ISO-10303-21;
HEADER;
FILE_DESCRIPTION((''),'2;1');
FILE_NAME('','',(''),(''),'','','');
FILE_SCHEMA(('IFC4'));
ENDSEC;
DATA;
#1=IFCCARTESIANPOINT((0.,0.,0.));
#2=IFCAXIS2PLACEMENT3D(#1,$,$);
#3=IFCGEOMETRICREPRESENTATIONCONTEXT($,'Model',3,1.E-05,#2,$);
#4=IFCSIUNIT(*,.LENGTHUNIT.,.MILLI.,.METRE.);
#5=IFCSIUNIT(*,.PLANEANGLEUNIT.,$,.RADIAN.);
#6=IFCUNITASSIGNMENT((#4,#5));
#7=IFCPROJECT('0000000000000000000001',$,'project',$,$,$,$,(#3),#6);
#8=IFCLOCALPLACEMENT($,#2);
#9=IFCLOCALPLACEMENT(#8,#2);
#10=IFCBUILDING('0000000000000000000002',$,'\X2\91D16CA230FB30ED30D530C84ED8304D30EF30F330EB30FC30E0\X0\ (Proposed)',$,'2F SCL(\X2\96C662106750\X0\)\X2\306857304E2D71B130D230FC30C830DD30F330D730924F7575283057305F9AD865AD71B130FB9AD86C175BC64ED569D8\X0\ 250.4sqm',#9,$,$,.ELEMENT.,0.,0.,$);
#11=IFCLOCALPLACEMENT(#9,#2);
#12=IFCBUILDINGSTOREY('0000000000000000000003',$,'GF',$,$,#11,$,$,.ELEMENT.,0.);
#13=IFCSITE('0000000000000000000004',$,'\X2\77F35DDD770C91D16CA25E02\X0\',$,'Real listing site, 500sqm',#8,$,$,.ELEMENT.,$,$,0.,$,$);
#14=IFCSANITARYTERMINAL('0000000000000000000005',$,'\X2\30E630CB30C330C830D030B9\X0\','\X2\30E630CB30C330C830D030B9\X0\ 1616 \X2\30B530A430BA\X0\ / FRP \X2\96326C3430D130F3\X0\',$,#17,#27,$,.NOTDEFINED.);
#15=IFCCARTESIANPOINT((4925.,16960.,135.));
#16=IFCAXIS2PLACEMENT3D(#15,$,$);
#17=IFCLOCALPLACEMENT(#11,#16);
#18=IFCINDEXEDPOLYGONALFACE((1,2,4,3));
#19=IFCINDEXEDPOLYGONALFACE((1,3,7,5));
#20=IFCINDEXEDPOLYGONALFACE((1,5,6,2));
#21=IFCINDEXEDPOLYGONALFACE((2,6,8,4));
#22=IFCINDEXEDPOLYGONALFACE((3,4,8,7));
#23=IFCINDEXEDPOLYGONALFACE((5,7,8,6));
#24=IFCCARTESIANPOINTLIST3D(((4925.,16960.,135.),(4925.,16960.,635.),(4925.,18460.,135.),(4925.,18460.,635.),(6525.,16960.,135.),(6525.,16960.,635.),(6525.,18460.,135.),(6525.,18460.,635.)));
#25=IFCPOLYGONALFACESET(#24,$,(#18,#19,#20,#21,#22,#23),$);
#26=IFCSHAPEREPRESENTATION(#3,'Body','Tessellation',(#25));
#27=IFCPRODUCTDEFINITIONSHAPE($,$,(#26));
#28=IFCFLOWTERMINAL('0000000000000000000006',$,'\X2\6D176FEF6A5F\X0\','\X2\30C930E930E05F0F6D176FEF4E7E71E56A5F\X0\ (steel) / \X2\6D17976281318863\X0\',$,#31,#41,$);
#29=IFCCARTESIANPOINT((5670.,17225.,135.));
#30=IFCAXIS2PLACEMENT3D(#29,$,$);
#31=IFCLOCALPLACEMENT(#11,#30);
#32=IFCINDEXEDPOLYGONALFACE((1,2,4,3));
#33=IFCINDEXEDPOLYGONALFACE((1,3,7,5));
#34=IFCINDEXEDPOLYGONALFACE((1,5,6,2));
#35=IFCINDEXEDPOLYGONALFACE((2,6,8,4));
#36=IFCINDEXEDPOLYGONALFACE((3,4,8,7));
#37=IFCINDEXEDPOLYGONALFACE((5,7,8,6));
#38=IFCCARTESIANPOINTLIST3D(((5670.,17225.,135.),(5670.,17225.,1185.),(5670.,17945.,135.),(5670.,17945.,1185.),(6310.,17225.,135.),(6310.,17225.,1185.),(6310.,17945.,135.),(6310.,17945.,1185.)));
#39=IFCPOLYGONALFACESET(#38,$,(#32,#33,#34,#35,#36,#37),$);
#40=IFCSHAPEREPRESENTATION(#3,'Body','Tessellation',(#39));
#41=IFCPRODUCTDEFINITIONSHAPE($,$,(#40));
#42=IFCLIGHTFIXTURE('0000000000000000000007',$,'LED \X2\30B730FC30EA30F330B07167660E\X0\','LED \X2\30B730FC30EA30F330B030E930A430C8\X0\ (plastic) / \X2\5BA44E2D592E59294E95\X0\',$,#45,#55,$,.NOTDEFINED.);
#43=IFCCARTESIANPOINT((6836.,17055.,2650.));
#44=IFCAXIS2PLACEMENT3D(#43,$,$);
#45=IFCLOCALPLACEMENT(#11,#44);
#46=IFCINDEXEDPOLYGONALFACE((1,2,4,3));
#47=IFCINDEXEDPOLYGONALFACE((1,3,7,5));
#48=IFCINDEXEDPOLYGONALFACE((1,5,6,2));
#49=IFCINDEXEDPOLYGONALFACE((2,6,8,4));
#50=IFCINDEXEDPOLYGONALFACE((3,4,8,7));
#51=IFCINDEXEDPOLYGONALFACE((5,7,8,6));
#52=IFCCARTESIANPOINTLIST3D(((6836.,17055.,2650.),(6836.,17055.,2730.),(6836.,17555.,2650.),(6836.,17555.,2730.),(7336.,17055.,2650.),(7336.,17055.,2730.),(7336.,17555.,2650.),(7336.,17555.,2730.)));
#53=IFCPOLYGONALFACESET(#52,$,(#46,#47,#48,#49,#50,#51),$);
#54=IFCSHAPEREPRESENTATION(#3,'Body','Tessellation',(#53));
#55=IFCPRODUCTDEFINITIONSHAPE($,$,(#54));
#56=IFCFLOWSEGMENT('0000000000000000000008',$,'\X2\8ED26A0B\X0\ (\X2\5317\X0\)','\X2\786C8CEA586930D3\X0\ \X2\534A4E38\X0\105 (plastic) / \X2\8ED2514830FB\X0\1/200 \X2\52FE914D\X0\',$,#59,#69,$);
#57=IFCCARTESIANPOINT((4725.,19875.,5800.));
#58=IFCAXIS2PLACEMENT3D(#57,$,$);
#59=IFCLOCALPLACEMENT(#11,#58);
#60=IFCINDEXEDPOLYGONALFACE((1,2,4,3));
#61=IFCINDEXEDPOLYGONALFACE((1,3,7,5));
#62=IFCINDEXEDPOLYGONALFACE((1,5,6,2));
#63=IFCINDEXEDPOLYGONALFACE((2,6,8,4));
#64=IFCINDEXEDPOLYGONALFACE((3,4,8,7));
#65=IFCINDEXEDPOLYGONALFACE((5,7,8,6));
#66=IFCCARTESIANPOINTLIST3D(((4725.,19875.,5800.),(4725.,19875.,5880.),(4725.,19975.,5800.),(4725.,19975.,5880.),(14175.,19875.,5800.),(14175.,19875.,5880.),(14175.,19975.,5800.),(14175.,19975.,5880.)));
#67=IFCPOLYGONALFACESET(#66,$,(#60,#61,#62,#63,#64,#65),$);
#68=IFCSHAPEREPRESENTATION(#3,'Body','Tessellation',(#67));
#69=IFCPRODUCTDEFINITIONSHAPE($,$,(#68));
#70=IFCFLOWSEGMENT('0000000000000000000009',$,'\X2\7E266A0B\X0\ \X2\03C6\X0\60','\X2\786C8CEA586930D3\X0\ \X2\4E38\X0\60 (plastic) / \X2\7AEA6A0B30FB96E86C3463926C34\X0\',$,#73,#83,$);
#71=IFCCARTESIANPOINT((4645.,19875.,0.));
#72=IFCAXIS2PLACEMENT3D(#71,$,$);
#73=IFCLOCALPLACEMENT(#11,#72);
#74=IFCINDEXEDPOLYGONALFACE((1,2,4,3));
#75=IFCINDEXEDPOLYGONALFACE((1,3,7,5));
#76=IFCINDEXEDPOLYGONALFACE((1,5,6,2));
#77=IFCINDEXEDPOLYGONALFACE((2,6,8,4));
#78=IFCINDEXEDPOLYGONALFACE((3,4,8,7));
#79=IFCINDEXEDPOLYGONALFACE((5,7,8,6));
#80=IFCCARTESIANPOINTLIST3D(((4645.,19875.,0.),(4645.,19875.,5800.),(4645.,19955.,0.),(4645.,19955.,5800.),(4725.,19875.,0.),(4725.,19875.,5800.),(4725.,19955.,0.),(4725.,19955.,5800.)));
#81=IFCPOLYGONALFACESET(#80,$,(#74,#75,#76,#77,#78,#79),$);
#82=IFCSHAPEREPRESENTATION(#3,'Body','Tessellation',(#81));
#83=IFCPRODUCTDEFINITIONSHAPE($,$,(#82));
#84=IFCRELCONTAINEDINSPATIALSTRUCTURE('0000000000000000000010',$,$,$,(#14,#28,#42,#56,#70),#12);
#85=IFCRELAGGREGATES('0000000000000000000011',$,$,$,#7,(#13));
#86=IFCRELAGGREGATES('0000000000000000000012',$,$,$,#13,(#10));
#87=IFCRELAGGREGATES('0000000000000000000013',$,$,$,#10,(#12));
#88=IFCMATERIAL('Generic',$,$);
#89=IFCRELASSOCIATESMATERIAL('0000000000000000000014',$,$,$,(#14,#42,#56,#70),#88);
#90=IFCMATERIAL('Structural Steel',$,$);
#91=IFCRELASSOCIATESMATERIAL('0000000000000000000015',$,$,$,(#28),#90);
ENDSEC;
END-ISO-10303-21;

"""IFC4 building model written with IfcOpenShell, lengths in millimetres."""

from ifc_helpers import new_model, si_unit, frame, frame_2d, origin, place, context, project, spatial, rectangle, extrude, material, element, save


model = new_model("IFC4")

# Units and contexts
model_context = context("Model", 3, precision=1e-05, world=origin())
ifc_project = project(units=[si_unit("LENGTHUNIT", "METRE", prefix="MILLI"), si_unit("PLANEANGLEUNIT", "RADIAN")], contexts=[model_context])

# Site, building, storey
site_placement = place(None, origin())
site = spatial("IfcSite", under=ifc_project, at=site_placement, Name="石川県金沢市", ObjectType="Real listing site, 500sqm", CompositionType="ELEMENT", RefElevation=0.0)
building_placement = place(site_placement, origin())
building = spatial("IfcBuilding", under=site, at=building_placement, Name="金沢・ロフト付きワンルーム (Proposed)", ObjectType="2F SCL(集成材)と地中熱ヒートポンプを併用した高断熱・高気密仕様 250.4sqm", CompositionType="ELEMENT", ElevationOfRefHeight=0.0, ElevationOfTerrain=0.0)
storey_placement = place(building_placement, origin())
storey = spatial("IfcBuildingStorey", under=building, at=storey_placement, Name="GF", CompositionType="ELEMENT", Elevation=0.0)

# Sanitary terminal
ifc_material_1 = material(Name="Generic")
sanitary_terminal_placement = place(storey_placement, frame((4925.0, 16960.0, 135.0)))
element("IfcSanitaryTerminal", 1, at=sanitary_terminal_placement, inside=storey, material=ifc_material_1, Name="ユニットバス", Description="ユニットバス 1616 サイズ / FRP 防水パン", PredefinedType="NOTDEFINED", context=model_context, shape_type="SweptSolid", body=[
    extrude(rectangle(XDim=1600.0, YDim=1500.0, at=frame_2d((800.0, 750.0))), frame((4925.0, 16960.0, 135.0)), (0.0, 0.0, 1.0), 500.0),
])

# Flow terminal
ifc_material_2 = material(Name="Structural Steel")
flow_terminal_placement = place(storey_placement, frame((5670.0, 17225.0, 135.0)))
element("IfcFlowTerminal", 2, at=flow_terminal_placement, inside=storey, material=ifc_material_2, Name="洗濯機", Description="ドラム式洗濯乾燥機 (steel) / 洗面脱衣", context=model_context, shape_type="SweptSolid", body=[
    extrude(rectangle(XDim=640.0, YDim=720.0, at=frame_2d((320.0, 360.0))), frame((5670.0, 17225.0, 135.0)), (0.0, 0.0, 1.0), 1050.0),
])

# Light fixture
light_fixture_placement = place(storey_placement, frame((6836.0, 17055.0, 2650.0)))
element("IfcLightFixture", 3, at=light_fixture_placement, inside=storey, material=ifc_material_1, Name="LED シーリング照明", Description="LED シーリングライト (plastic) / 室中央天井", PredefinedType="NOTDEFINED", context=model_context, shape_type="SweptSolid", body=[
    extrude(rectangle(XDim=500.0, YDim=500.0, at=frame_2d((250.0, 250.0))), frame((6836.0, 17055.0, 2650.0)), (0.0, 0.0, 1.0), 80.0),
])

# Flow segments
flow_segment_1_placement = place(storey_placement, frame((4725.0, 19875.0, 5800.0)))
element("IfcFlowSegment", 4, at=flow_segment_1_placement, inside=storey, material=ifc_material_1, Name="軒樋 (北)", Description="硬質塩ビ 半丸105 (plastic) / 軒先・1/200 勾配", context=model_context, shape_type="SweptSolid", body=[
    extrude(rectangle(XDim=9450.0, YDim=100.0, at=frame_2d((4725.0, 50.0))), frame((4725.0, 19875.0, 5800.0)), (0.0, 0.0, 1.0), 80.0),
])
flow_segment_2_placement = place(storey_placement, frame((4645.0, 19875.0, 0.0)))
element("IfcFlowSegment", 5, at=flow_segment_2_placement, inside=storey, material=ifc_material_1, Name="縦樋 φ60", Description="硬質塩ビ 丸60 (plastic) / 竪樋・雨水排水", context=model_context, shape_type="SweptSolid", body=[
    extrude(rectangle(XDim=80.0, YDim=80.0, at=frame_2d((40.0, 40.0))), frame((4645.0, 19875.0, 0.0)), (0.0, 0.0, 1.0), 5800.0),
])

save(model, "model.ifc")
